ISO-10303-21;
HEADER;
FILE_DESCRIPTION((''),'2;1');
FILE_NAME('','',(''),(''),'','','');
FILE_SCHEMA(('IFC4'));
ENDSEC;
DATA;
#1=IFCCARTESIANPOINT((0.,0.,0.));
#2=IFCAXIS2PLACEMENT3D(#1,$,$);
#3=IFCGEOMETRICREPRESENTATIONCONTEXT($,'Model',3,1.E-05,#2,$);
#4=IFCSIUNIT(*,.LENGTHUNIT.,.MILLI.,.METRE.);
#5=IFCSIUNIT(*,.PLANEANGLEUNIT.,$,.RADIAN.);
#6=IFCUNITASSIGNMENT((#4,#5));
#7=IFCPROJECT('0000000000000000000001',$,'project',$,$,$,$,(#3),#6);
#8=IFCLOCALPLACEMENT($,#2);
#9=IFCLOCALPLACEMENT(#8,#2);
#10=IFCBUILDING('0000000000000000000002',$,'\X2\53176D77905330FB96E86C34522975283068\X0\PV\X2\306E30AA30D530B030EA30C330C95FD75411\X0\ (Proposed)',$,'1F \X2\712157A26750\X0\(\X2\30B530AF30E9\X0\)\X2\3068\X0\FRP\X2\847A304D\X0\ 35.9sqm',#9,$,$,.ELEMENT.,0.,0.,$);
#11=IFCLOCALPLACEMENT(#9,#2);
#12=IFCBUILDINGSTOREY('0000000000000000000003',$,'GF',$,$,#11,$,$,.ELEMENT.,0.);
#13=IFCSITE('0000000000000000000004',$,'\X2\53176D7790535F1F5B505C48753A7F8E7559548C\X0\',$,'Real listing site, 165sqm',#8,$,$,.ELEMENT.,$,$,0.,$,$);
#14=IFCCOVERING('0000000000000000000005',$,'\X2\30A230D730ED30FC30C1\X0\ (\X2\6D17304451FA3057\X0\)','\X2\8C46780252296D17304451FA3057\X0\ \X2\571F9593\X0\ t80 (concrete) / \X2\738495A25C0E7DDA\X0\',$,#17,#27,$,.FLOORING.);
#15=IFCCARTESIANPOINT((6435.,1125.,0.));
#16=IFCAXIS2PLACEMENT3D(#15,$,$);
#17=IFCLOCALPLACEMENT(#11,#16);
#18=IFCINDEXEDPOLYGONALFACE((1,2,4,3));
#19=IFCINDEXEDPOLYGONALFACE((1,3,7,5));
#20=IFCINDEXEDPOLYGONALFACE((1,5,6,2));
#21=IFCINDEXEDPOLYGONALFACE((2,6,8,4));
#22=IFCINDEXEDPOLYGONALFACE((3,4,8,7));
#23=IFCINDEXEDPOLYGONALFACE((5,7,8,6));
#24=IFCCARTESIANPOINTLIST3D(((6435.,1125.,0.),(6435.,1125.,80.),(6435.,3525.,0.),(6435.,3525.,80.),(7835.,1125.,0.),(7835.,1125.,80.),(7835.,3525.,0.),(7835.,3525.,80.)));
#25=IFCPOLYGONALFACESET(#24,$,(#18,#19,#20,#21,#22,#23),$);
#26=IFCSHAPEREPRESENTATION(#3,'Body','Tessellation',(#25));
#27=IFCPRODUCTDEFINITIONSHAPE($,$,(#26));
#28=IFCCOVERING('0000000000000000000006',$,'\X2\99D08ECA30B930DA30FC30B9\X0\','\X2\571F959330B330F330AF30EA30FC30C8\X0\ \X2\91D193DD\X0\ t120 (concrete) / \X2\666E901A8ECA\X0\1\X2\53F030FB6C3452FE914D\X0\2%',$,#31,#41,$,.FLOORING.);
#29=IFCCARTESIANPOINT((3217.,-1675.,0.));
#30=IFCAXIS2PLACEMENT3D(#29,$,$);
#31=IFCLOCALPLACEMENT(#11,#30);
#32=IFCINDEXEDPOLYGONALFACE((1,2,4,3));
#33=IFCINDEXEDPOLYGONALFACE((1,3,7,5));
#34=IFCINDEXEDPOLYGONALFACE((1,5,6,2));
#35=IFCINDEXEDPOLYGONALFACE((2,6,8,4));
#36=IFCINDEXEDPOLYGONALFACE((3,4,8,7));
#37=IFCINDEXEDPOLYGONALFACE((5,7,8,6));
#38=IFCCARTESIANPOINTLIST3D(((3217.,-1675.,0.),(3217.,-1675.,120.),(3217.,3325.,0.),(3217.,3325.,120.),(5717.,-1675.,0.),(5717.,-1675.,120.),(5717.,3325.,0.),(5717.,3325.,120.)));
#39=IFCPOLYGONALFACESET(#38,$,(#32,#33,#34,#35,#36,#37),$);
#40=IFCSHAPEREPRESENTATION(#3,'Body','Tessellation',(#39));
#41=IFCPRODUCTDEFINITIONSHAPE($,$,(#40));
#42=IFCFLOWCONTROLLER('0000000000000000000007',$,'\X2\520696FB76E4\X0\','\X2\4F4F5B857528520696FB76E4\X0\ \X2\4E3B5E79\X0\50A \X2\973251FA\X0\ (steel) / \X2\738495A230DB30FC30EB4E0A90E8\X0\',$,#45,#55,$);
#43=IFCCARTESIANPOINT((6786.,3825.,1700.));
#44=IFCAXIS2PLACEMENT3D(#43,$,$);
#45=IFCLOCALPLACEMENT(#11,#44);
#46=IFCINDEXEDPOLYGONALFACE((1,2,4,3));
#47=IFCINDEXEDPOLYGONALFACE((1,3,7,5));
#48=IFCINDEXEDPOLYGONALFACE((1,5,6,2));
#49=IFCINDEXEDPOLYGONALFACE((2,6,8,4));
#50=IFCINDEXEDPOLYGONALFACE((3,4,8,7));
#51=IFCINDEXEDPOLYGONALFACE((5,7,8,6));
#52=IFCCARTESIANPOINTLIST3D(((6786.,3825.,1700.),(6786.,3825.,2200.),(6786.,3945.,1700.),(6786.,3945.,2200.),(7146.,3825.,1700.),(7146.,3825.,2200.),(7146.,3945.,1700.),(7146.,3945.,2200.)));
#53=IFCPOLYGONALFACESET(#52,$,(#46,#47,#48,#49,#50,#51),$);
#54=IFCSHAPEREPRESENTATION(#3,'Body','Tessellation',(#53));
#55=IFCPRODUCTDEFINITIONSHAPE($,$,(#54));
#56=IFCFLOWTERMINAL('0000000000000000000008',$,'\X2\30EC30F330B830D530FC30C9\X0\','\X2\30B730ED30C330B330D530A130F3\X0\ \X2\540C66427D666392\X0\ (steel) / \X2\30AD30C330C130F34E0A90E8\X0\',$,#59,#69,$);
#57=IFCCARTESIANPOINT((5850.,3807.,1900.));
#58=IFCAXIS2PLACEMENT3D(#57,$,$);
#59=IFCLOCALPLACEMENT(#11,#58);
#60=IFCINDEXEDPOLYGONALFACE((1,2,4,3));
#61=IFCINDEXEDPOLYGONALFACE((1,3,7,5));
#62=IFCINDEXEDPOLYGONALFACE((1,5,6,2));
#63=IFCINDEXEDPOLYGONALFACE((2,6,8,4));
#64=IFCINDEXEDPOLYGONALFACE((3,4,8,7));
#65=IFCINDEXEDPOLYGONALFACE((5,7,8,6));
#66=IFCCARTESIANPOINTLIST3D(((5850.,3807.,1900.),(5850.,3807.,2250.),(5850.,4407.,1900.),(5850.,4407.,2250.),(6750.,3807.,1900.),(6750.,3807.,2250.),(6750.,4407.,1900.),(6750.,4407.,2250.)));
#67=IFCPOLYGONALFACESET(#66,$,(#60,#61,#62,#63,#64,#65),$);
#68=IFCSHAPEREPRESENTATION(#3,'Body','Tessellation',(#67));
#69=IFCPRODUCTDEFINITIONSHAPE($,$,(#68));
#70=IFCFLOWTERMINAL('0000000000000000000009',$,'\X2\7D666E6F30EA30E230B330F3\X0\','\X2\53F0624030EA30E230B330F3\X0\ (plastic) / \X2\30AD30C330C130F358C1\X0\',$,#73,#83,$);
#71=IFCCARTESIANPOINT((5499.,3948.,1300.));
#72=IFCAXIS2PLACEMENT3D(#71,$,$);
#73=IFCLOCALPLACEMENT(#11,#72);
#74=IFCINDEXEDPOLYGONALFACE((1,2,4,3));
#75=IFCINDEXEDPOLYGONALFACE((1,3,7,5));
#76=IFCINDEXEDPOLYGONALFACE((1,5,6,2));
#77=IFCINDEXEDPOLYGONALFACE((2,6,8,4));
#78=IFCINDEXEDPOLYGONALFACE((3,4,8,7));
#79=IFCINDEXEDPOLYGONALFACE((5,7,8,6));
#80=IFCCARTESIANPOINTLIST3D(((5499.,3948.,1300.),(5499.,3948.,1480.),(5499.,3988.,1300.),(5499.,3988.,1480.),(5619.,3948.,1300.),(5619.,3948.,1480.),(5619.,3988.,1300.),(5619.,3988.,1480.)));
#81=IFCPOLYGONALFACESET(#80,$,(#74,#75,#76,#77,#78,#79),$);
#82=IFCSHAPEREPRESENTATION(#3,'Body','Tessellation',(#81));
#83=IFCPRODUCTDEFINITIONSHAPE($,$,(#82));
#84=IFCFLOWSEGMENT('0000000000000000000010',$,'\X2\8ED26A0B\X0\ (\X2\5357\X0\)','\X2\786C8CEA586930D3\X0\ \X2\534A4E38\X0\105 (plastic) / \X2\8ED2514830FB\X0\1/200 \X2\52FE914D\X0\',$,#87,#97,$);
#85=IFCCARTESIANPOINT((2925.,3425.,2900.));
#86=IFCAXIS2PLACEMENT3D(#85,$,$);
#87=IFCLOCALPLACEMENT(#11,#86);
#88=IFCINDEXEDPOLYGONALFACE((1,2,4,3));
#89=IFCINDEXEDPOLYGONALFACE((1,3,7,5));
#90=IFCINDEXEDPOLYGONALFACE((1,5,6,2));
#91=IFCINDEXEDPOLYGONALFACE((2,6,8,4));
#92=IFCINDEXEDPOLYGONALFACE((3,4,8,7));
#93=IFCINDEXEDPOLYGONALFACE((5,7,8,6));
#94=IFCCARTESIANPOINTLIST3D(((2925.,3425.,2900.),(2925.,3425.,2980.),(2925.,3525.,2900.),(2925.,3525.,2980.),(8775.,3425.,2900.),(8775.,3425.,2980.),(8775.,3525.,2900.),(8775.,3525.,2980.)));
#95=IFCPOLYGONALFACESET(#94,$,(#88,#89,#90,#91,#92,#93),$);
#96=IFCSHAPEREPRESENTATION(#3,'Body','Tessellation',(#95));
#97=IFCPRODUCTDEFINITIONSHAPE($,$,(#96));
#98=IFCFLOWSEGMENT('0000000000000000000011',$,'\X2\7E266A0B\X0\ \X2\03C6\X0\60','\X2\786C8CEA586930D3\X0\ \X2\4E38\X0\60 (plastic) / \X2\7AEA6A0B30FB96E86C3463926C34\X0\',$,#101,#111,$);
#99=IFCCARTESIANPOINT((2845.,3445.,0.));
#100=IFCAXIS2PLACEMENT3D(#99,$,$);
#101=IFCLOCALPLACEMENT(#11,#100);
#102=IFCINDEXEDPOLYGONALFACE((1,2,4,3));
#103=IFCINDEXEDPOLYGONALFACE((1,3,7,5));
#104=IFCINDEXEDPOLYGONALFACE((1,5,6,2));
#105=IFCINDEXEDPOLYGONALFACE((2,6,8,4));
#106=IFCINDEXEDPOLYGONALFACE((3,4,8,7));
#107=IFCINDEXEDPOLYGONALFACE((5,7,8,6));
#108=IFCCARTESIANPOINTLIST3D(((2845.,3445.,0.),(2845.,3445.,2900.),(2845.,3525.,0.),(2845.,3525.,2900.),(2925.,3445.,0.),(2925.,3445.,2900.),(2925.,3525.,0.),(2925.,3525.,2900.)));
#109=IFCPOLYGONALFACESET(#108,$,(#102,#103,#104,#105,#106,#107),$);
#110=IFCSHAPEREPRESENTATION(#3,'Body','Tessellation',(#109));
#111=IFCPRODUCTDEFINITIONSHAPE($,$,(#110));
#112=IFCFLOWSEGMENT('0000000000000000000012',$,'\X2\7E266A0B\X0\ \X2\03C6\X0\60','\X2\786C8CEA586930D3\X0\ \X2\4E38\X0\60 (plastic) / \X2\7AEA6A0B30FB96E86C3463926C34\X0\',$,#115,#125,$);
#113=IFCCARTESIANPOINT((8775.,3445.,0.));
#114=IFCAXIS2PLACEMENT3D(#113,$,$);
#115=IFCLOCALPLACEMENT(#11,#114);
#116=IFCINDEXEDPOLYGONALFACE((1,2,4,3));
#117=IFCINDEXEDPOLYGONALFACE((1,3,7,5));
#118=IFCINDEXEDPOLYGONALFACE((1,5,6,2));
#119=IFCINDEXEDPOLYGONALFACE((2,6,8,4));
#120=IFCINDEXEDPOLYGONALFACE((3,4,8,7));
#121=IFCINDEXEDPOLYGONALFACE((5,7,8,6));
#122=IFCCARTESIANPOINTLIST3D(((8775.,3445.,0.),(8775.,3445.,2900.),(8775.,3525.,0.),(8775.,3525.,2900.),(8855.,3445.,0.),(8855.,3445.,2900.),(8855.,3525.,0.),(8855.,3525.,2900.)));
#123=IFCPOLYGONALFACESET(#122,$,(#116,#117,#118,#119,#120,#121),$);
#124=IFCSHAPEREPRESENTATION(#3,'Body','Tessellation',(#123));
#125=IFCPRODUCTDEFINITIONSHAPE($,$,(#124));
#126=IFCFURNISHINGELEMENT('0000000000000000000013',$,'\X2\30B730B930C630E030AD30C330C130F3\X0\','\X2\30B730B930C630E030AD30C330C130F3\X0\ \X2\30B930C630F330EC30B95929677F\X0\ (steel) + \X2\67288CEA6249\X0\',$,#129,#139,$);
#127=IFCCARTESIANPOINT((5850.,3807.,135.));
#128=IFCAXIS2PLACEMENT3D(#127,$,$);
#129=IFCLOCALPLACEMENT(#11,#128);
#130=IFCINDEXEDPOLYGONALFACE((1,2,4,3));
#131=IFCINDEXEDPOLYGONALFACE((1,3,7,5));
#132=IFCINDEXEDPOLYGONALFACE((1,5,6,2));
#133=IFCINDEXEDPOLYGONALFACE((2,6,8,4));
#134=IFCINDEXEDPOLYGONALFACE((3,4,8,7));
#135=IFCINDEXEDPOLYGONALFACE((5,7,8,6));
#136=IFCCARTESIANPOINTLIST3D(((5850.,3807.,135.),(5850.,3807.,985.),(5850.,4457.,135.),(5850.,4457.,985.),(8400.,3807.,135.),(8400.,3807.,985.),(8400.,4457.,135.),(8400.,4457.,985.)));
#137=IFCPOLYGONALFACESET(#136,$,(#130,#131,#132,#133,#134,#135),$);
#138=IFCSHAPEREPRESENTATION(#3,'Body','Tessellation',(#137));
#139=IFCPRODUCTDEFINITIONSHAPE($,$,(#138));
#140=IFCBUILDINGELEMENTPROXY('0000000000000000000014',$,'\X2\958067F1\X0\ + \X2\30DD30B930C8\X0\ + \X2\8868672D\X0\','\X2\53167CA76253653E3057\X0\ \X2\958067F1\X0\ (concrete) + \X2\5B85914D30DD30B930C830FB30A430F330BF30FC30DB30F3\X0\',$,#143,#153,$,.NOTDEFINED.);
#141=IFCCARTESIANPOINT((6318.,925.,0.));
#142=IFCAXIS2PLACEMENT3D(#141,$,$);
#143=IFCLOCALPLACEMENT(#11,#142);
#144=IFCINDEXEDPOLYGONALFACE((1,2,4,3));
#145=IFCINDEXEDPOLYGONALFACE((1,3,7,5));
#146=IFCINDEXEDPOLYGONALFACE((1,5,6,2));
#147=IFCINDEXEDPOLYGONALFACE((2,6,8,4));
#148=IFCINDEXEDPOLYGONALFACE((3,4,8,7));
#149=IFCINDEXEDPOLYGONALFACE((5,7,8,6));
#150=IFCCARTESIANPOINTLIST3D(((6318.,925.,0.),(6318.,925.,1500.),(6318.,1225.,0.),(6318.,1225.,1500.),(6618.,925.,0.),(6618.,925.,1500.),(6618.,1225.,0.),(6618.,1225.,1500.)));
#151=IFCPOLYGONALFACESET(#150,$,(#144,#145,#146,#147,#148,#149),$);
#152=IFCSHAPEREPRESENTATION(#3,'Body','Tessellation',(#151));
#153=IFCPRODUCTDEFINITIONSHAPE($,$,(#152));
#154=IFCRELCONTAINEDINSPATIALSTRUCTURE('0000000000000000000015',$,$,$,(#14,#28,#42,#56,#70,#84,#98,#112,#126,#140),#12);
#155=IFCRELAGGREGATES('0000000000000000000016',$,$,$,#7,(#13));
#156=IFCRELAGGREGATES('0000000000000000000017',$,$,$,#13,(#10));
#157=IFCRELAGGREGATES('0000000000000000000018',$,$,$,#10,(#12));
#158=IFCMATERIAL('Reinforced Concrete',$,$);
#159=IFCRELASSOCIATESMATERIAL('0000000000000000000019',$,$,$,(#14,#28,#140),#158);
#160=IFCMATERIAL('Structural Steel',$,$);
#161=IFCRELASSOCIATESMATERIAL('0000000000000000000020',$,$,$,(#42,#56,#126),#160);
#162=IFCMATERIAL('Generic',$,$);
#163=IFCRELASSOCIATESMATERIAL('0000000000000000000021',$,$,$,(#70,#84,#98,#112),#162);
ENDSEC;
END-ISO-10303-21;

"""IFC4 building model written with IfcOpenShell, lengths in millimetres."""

from ifc_helpers import new_model, si_unit, frame, frame_2d, origin, place, context, project, spatial, rectangle, extrude, material, element, save


model = new_model("IFC4")

# Units and contexts
model_context = context("Model", 3, precision=1e-05, world=origin())
ifc_project = project(units=[si_unit("LENGTHUNIT", "METRE", prefix="MILLI"), si_unit("PLANEANGLEUNIT", "RADIAN")], contexts=[model_context])

# Site, building, storey
site_placement = place(None, origin())
site = spatial("IfcSite", under=ifc_project, at=site_placement, Name="北海道弟子屈町美留和", ObjectType="Real listing site, 165sqm", CompositionType="ELEMENT", RefElevation=0.0)
building_placement = place(site_placement, origin())
building = spatial("IfcBuilding", under=site, at=building_placement, Name="北海道・雨水利用とPVのオフグリッド志向 (Proposed)", ObjectType="1F 無垢材(サクラ)とFRP葺き 35.9sqm", CompositionType="ELEMENT", ElevationOfRefHeight=0.0, ElevationOfTerrain=0.0)
storey_placement = place(building_placement, origin())
storey = spatial("IfcBuildingStorey", under=building, at=storey_placement, Name="GF", CompositionType="ELEMENT", Elevation=0.0)

# Shared definitions
ifc_material_1 = material(Name="Reinforced Concrete")

# Shared definitions
ifc_material_2 = material(Name="Structural Steel")

# Coverings
ifc_material_3 = material(Name="Generic")
covering_1_placement = place(storey_placement, frame((6435.0, 1125.0, 0.0)))
element("IfcCovering", 1, at=covering_1_placement, inside=storey, material=ifc_material_1, Name="アプローチ (洗い出し)", Description="豆砂利洗い出し 土間 t80 (concrete) / 玄関導線", PredefinedType="FLOORING", context=model_context, shape_type="SweptSolid", body=[
    extrude(rectangle(XDim=1400.0, YDim=2400.0, at=frame_2d((700.0, 1200.0))), frame((6435.0, 1125.0, 0.0)), (0.0, 0.0, 1.0), 80.0),
])
covering_2_placement = place(storey_placement, frame((3217.0, -1675.0, 0.0)))
element("IfcCovering", 2, at=covering_2_placement, inside=storey, material=ifc_material_1, Name="駐車スペース", Description="土間コンクリート 金鏝 t120 (concrete) / 普通車1台・水勾配2%", PredefinedType="FLOORING", context=model_context, shape_type="SweptSolid", body=[
    extrude(rectangle(XDim=2500.0, YDim=5000.0, at=frame_2d((1250.0, 2500.0))), frame((3217.0, -1675.0, 0.0)), (0.0, 0.0, 1.0), 120.0),
])

# Flow controller
flow_controller_placement = place(storey_placement, frame((6786.0, 3825.0, 1700.0)))
element("IfcFlowController", 3, at=flow_controller_placement, inside=storey, material=ifc_material_2, Name="分電盤", Description="住宅用分電盤 主幹50A 露出 (steel) / 玄関ホール上部", context=model_context, shape_type="SweptSolid", body=[
    extrude(rectangle(XDim=360.0, YDim=120.0, at=frame_2d((180.0, 60.0))), frame((6786.0, 3825.0, 1700.0)), (0.0, 0.0, 1.0), 500.0),
])

# Flow terminals
flow_terminal_1_placement = place(storey_placement, frame((5850.0, 3807.0, 1900.0)))
element("IfcFlowTerminal", 4, at=flow_terminal_1_placement, inside=storey, material=ifc_material_2, Name="レンジフード", Description="シロッコファン 同時給排 (steel) / キッチン上部", context=model_context, shape_type="SweptSolid", body=[
    extrude(rectangle(XDim=900.0, YDim=600.0, at=frame_2d((450.0, 300.0))), frame((5850.0, 3807.0, 1900.0)), (0.0, 0.0, 1.0), 350.0),
])
flow_terminal_2_placement = place(storey_placement, frame((5499.0, 3948.0, 1300.0)))
element("IfcFlowTerminal", 5, at=flow_terminal_2_placement, inside=storey, material=ifc_material_3, Name="給湯リモコン", Description="台所リモコン (plastic) / キッチン壁", context=model_context, shape_type="SweptSolid", body=[
    extrude(rectangle(XDim=120.0, YDim=40.0, at=frame_2d((60.0, 20.0))), frame((5499.0, 3948.0, 1300.0)), (0.0, 0.0, 1.0), 180.0),
])

# Flow segments
flow_segment_1_placement = place(storey_placement, frame((2925.0, 3425.0, 2900.0)))
element("IfcFlowSegment", 6, at=flow_segment_1_placement, inside=storey, material=ifc_material_3, Name="軒樋 (南)", Description="硬質塩ビ 半丸105 (plastic) / 軒先・1/200 勾配", context=model_context, shape_type="SweptSolid", body=[
    extrude(rectangle(XDim=5850.0, YDim=100.0, at=frame_2d((2925.0, 50.0))), frame((2925.0, 3425.0, 2900.0)), (0.0, 0.0, 1.0), 80.0),
])
flow_segment_2_placement = place(storey_placement, frame((2845.0, 3445.0, 0.0)))
element("IfcFlowSegment", 7, at=flow_segment_2_placement, inside=storey, material=ifc_material_3, Name="縦樋 φ60", Description="硬質塩ビ 丸60 (plastic) / 竪樋・雨水排水", context=model_context, shape_type="SweptSolid", body=[
    extrude(rectangle(XDim=80.0, YDim=80.0, at=frame_2d((40.0, 40.0))), frame((2845.0, 3445.0, 0.0)), (0.0, 0.0, 1.0), 2900.0),
])
flow_segment_3_placement = place(storey_placement, frame((8775.0, 3445.0, 0.0)))
element("IfcFlowSegment", 8, at=flow_segment_3_placement, inside=storey, material=ifc_material_3, Name="縦樋 φ60", Description="硬質塩ビ 丸60 (plastic) / 竪樋・雨水排水", context=model_context, shape_type="SweptSolid", body=[
    extrude(rectangle(XDim=80.0, YDim=80.0, at=frame_2d((40.0, 40.0))), frame((8775.0, 3445.0, 0.0)), (0.0, 0.0, 1.0), 2900.0),
])

# Furnishing element
furnishing_placement = place(storey_placement, frame((5850.0, 3807.0, 135.0)))
element("IfcFurnishingElement", 9, at=furnishing_placement, inside=storey, material=ifc_material_2, Name="システムキッチン", Description="システムキッチン ステンレス天板 (steel) + 木質扉", context=model_context, shape_type="SweptSolid", body=[
    extrude(rectangle(XDim=2550.0, YDim=650.0, at=frame_2d((1275.0, 325.0))), frame((5850.0, 3807.0, 135.0)), (0.0, 0.0, 1.0), 850.0),
])

# Building element proxy
proxy_placement = place(storey_placement, frame((6318.0, 925.0, 0.0)))
element("IfcBuildingElementProxy", 10, at=proxy_placement, inside=storey, material=ifc_material_1, Name="門柱 + ポスト + 表札", Description="化粧打放し 門柱 (concrete) + 宅配ポスト・インターホン", PredefinedType="NOTDEFINED", context=model_context, shape_type="SweptSolid", body=[
    extrude(rectangle(XDim=300.0, YDim=300.0, at=frame_2d((150.0, 150.0))), frame((6318.0, 925.0, 0.0)), (0.0, 0.0, 1.0), 1500.0),
])

save(model, "model.ifc")
